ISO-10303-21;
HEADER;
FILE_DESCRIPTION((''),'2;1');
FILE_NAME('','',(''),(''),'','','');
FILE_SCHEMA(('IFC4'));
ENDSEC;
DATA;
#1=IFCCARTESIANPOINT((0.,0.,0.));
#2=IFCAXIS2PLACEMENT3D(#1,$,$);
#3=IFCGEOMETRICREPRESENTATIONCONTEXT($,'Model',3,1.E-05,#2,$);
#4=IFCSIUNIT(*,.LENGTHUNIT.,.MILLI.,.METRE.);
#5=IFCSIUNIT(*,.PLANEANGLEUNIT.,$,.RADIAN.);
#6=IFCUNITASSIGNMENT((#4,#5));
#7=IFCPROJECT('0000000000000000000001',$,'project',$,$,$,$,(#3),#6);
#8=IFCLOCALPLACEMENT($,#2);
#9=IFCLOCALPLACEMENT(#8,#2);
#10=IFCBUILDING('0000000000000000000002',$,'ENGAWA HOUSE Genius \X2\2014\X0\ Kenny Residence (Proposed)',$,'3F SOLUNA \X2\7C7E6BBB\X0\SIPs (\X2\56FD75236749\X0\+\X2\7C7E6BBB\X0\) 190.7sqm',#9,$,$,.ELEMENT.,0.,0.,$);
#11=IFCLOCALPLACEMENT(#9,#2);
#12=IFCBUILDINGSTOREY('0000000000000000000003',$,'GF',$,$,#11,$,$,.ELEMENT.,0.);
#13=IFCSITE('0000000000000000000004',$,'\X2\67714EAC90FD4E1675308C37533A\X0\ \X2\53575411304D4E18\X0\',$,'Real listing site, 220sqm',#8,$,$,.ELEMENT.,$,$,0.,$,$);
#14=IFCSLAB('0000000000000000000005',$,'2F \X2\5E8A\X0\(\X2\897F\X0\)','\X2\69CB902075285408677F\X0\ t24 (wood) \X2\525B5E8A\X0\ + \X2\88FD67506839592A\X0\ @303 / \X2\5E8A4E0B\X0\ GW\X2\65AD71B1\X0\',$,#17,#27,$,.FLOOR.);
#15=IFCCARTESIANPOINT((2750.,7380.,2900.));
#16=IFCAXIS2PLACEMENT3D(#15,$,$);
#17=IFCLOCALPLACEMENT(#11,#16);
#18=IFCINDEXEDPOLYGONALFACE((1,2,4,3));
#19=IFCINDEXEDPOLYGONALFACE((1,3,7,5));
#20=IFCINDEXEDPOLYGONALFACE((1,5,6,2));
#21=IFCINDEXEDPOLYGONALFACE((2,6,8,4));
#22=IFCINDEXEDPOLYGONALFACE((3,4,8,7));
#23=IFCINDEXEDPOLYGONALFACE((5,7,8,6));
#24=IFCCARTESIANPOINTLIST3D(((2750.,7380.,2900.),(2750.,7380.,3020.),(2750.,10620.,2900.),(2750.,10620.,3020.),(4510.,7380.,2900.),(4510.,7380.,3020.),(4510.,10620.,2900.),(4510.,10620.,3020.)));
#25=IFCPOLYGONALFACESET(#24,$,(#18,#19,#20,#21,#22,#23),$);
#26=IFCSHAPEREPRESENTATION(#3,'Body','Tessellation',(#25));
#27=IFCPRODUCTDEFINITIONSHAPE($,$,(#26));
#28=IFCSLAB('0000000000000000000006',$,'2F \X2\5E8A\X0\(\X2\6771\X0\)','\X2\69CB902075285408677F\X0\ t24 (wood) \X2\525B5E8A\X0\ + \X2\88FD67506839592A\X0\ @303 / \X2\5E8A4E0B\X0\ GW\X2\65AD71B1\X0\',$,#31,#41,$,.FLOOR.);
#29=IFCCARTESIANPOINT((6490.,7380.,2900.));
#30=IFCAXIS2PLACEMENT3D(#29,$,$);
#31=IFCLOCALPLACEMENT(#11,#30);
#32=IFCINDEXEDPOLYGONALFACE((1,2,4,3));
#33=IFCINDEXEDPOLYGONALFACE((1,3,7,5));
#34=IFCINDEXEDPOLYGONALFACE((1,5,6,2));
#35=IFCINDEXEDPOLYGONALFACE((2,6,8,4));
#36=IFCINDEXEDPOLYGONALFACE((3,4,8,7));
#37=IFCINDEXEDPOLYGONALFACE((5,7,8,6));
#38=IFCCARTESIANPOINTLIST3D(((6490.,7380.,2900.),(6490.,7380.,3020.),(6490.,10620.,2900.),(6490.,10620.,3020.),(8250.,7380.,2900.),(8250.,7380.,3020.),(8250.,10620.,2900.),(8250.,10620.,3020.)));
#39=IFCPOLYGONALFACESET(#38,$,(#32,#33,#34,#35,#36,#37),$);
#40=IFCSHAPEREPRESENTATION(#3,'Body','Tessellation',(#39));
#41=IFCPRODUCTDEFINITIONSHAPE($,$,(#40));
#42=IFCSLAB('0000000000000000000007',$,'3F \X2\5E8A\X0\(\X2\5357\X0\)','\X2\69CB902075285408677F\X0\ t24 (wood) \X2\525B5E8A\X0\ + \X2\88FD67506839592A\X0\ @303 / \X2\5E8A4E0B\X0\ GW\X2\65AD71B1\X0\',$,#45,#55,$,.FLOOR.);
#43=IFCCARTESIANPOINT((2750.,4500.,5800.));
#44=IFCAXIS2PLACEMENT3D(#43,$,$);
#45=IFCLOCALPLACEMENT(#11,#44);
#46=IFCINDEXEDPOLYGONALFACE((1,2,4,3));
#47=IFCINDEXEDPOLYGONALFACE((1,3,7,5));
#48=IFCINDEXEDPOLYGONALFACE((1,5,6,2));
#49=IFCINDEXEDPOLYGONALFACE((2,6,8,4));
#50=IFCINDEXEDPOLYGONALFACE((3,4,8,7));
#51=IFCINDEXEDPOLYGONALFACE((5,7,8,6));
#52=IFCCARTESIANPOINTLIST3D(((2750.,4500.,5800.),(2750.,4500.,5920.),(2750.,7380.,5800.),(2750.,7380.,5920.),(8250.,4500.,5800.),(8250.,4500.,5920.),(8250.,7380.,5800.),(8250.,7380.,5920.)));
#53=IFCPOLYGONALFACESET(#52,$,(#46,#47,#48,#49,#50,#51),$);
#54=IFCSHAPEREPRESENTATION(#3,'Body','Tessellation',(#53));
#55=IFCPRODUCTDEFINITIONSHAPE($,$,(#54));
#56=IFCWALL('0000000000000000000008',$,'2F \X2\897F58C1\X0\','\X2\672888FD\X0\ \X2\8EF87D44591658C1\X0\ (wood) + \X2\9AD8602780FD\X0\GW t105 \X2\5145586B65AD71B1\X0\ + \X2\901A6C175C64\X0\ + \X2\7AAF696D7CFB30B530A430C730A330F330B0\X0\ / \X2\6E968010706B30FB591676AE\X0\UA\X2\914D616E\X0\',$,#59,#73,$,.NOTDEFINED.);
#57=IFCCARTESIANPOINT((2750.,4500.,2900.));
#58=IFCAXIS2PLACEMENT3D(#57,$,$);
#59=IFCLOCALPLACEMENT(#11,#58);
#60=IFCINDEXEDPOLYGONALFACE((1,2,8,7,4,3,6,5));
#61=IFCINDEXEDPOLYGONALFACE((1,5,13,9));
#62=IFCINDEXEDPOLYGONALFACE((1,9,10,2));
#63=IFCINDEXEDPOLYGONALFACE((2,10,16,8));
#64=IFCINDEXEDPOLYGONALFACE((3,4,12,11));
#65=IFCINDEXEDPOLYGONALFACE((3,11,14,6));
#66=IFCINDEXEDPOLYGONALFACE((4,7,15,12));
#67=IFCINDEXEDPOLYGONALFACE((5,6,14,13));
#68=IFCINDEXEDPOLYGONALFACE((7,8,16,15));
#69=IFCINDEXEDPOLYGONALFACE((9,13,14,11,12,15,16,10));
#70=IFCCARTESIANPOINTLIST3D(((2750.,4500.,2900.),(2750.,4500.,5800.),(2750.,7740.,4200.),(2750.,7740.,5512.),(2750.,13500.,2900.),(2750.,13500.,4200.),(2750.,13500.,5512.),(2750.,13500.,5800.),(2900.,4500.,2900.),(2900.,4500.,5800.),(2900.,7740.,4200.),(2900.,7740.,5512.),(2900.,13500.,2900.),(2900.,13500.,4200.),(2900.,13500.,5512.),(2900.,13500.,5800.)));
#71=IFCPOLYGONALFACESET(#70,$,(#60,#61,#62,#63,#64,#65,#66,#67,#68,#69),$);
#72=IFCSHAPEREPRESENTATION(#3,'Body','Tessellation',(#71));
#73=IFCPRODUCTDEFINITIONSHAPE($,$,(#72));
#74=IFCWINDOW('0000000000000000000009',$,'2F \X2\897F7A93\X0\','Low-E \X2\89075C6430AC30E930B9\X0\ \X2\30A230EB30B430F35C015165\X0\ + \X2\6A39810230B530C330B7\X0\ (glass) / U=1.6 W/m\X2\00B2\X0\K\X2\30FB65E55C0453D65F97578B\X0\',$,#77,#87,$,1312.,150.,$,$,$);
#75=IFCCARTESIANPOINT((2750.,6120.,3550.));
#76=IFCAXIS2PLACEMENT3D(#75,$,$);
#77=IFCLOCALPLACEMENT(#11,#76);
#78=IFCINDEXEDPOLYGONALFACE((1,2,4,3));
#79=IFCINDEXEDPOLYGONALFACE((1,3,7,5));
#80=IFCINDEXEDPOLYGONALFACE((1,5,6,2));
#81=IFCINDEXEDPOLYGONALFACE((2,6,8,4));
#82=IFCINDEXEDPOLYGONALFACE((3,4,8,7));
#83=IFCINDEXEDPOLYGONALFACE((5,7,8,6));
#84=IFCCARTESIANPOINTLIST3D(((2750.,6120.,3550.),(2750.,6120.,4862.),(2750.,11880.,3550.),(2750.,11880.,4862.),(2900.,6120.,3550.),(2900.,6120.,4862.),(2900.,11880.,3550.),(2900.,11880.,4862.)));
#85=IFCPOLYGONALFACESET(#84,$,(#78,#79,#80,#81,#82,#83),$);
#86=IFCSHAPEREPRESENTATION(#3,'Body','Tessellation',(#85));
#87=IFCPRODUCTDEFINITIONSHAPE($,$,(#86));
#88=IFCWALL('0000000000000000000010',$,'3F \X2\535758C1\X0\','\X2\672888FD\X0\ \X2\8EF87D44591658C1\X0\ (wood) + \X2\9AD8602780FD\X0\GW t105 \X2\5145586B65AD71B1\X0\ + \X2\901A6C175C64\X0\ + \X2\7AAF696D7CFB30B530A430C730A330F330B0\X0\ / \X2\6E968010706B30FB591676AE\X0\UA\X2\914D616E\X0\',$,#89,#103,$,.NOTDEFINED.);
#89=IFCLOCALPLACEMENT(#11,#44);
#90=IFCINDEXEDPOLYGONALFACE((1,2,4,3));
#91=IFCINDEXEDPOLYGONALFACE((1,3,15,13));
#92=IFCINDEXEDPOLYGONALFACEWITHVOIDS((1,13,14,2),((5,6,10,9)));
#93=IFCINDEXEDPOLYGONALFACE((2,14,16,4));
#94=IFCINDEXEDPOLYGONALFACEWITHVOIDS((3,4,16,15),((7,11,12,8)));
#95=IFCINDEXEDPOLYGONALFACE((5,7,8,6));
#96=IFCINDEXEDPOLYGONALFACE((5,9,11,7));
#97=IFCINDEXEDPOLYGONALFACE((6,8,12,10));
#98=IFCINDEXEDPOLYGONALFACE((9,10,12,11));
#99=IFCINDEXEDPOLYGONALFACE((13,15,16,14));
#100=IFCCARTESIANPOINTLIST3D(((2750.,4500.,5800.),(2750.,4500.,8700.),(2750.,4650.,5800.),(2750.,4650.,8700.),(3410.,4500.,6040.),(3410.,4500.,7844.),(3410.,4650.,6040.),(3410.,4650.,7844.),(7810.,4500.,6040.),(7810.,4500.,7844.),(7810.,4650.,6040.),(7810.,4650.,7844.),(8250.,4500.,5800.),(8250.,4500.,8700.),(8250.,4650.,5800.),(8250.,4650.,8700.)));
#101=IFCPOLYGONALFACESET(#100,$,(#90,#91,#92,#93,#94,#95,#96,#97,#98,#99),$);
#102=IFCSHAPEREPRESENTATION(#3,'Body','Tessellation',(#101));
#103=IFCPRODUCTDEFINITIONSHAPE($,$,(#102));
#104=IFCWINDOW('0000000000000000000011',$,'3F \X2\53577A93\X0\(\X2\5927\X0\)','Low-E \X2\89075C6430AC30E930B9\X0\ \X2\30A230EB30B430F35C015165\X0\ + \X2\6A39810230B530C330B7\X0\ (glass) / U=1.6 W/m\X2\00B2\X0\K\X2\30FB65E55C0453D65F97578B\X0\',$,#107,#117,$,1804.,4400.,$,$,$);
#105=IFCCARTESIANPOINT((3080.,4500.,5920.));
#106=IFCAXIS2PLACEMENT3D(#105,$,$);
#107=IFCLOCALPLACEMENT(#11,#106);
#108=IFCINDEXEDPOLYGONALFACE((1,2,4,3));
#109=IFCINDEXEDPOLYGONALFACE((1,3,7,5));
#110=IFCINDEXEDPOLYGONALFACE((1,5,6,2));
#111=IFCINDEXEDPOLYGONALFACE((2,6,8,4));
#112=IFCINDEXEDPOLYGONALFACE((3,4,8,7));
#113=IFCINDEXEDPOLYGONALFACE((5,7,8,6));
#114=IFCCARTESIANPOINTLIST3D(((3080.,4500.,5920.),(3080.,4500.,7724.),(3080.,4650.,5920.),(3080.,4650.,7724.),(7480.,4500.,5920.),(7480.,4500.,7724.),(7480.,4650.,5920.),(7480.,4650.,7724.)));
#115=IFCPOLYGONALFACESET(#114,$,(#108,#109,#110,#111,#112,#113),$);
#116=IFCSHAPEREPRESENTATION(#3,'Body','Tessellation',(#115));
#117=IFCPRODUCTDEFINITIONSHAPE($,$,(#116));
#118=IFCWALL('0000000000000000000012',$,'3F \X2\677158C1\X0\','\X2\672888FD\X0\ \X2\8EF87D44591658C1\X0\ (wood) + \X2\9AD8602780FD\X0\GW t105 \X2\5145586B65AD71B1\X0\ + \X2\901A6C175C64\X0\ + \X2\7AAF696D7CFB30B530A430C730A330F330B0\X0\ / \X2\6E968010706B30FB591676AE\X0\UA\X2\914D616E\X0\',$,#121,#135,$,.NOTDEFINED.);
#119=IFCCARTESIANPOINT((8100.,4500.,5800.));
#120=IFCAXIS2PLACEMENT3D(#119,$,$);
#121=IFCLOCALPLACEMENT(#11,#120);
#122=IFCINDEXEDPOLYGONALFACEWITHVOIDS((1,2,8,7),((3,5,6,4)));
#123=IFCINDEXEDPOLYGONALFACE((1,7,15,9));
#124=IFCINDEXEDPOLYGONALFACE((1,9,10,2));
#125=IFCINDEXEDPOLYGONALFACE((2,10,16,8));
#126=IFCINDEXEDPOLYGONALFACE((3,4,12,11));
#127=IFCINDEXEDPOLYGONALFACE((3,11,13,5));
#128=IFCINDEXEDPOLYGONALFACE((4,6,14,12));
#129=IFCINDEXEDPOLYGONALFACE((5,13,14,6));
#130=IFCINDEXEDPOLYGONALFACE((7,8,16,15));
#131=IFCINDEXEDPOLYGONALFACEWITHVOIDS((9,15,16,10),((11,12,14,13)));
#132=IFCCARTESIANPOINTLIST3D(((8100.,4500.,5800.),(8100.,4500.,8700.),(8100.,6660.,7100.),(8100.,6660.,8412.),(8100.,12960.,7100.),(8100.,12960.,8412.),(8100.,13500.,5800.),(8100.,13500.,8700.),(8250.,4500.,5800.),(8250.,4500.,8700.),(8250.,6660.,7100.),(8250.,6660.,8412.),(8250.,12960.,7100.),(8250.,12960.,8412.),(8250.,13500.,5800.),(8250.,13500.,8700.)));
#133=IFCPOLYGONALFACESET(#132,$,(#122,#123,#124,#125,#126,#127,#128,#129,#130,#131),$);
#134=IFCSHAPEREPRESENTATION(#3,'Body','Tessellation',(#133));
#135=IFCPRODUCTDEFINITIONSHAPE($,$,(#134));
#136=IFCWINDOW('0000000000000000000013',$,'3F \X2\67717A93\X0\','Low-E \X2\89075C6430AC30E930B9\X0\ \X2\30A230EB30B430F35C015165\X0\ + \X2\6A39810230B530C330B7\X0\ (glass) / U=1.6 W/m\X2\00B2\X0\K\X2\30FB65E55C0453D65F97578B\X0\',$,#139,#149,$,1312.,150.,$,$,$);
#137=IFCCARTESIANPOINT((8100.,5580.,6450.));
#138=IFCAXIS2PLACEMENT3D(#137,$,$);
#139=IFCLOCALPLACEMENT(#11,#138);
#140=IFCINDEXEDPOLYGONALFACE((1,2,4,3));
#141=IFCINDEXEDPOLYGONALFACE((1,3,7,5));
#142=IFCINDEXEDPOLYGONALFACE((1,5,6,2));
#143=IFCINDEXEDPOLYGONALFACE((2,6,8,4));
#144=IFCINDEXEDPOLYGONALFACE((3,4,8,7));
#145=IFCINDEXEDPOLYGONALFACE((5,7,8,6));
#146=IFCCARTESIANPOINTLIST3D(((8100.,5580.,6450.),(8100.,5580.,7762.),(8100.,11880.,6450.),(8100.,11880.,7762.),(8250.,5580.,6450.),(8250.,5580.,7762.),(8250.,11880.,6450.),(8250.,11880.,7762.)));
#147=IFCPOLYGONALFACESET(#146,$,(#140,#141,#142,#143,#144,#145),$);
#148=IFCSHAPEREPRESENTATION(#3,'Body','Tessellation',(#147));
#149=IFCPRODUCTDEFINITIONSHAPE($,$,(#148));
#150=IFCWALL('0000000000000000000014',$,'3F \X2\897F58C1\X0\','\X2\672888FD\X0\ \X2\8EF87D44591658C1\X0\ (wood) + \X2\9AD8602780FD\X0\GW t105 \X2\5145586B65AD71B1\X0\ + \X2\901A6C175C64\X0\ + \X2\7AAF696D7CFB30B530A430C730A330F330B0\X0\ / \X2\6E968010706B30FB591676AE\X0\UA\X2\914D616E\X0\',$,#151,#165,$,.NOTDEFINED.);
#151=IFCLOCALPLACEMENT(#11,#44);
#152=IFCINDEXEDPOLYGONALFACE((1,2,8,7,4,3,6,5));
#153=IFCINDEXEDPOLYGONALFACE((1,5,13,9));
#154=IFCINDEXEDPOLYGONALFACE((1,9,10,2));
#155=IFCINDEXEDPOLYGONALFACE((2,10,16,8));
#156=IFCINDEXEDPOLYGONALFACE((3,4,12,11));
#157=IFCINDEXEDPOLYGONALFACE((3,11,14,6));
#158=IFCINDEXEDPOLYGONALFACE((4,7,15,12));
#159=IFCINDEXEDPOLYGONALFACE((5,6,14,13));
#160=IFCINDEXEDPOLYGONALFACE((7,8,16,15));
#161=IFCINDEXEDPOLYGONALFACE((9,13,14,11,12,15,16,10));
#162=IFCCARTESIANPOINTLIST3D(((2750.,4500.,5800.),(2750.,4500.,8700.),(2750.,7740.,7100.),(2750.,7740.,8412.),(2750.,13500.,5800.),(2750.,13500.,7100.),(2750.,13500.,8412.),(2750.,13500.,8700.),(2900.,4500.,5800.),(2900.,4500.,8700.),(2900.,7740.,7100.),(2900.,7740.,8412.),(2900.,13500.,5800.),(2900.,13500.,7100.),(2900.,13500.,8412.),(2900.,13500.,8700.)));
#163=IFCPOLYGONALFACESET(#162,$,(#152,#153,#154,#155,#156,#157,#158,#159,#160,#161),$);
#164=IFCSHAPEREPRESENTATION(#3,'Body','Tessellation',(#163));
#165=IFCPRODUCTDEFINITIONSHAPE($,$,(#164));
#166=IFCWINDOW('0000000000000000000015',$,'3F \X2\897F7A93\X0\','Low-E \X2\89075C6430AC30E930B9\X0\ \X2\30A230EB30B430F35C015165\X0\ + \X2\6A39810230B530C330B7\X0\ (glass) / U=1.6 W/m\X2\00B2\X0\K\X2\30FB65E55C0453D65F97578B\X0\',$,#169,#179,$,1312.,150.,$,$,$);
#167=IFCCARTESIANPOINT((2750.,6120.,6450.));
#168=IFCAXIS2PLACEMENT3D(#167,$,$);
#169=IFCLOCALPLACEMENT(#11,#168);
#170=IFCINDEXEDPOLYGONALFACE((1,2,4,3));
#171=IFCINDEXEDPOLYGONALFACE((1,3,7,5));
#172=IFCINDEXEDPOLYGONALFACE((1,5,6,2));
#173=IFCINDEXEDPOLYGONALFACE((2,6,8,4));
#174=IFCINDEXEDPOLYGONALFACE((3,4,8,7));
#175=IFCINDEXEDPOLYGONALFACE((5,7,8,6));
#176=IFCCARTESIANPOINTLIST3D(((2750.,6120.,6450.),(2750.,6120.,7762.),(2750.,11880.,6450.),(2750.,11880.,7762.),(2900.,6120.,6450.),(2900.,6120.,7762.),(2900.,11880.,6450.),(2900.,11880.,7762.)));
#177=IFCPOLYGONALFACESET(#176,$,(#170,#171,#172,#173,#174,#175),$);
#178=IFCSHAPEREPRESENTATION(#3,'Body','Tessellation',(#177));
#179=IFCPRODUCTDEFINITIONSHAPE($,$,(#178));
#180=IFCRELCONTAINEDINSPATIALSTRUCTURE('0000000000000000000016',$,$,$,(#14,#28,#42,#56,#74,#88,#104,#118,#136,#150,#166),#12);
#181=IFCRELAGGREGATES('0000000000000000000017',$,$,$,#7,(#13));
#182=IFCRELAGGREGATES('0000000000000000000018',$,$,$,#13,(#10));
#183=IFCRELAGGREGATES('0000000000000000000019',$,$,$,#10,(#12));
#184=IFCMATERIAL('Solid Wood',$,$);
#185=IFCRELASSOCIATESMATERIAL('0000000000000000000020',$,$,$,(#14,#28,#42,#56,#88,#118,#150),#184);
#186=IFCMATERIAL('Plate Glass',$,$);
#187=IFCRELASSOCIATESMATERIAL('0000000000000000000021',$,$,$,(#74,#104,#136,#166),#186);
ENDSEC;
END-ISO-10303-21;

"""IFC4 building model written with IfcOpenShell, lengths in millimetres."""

from ifc_helpers import new_model, si_unit, frame, frame_2d, origin, place, context, project, spatial, rectangle, extrude, material, element, fill, save


model = new_model("IFC4")

# Units and contexts
model_context = context("Model", 3, precision=1e-05, world=origin())
ifc_project = project(units=[si_unit("LENGTHUNIT", "METRE", prefix="MILLI"), si_unit("PLANEANGLEUNIT", "RADIAN")], contexts=[model_context])

# Site, building, storey
site_placement = place(None, origin())
site = spatial("IfcSite", under=ifc_project, at=site_placement, Name="東京都世田谷区 南向き丘", ObjectType="Real listing site, 220sqm", CompositionType="ELEMENT", RefElevation=0.0)
building_placement = place(site_placement, origin())
building = spatial("IfcBuilding", under=site, at=building_placement, Name="ENGAWA HOUSE Genius — Kenny Residence (Proposed)", ObjectType="3F SOLUNA 籾殻SIPs (国産杉+籾殻) 190.7sqm", CompositionType="ELEMENT", ElevationOfRefHeight=0.0, ElevationOfTerrain=0.0)
storey_placement = place(building_placement, origin())
storey = spatial("IfcBuildingStorey", under=building, at=storey_placement, Name="GF", CompositionType="ELEMENT", Elevation=0.0)

# Slabs
ifc_material_1 = material(Name="Solid Wood")
slab_1_placement = place(storey_placement, frame((2750.0, 7380.0, 2900.0)))
element("IfcSlab", 1, at=slab_1_placement, inside=storey, material=ifc_material_1, Name="2F 床(西)", Description="構造用合板 t24 (wood) 剛床 + 製材根太 @303 / 床下 GW断熱", PredefinedType="FLOOR", context=model_context, shape_type="SweptSolid", body=[
    extrude(rectangle(XDim=1760.0, YDim=3240.0, at=frame_2d((880.0, 1620.0))), frame((2750.0, 7380.0, 2900.0)), (0.0, 0.0, 1.0), 120.0),
])
slab_2_placement = place(storey_placement, frame((6490.0, 7380.0, 2900.0)))
element("IfcSlab", 2, at=slab_2_placement, inside=storey, material=ifc_material_1, Name="2F 床(東)", Description="構造用合板 t24 (wood) 剛床 + 製材根太 @303 / 床下 GW断熱", PredefinedType="FLOOR", context=model_context, shape_type="SweptSolid", body=[
    extrude(rectangle(XDim=1760.0, YDim=3240.0, at=frame_2d((880.0, 1620.0))), frame((6490.0, 7380.0, 2900.0)), (0.0, 0.0, 1.0), 120.0),
])
slab_3_placement = place(storey_placement, frame((2750.0, 4500.0, 5800.0)))
element("IfcSlab", 3, at=slab_3_placement, inside=storey, material=ifc_material_1, Name="3F 床(南)", Description="構造用合板 t24 (wood) 剛床 + 製材根太 @303 / 床下 GW断熱", PredefinedType="FLOOR", context=model_context, shape_type="SweptSolid", body=[
    extrude(rectangle(XDim=5500.0, YDim=2880.0, at=frame_2d((2750.0, 1440.0))), frame((2750.0, 4500.0, 5800.0)), (0.0, 0.0, 1.0), 120.0),
])

# Walls, openings, windows
wall_1_placement = place(storey_placement, frame((2750.0, 4500.0, 2900.0)))
wall_1 = element("IfcWall", 4, at=wall_1_placement, inside=storey, material=ifc_material_1, Name="2F 西壁", Description="木製 軸組外壁 (wood) + 高性能GW t105 充填断熱 + 通気層 + 窯業系サイディング / 準耐火・外皮UA配慮", PredefinedType="NOTDEFINED", context=model_context, shape_type="SweptSolid", body=[
    extrude(rectangle(XDim=150.0, YDim=9000.0, at=frame_2d((75.0, 4500.0))), frame((2750.0, 4500.0, 2900.0)), (0.0, 0.0, 1.0), 2900.0),
])
opening_1_placement = place(storey_placement, frame((2750.0, 6120.0, 3550.0)))
opening_1 = element("IfcOpeningElement", 5, at=opening_1_placement, cuts=wall_1, PredefinedType="NOTDEFINED", context=model_context, shape_type="SweptSolid", body=[
    extrude(rectangle(XDim=150.0, YDim=5760.0, at=frame_2d((75.0, 2880.0))), frame((2750.0, 6120.0, 3550.0)), (0.0, 0.0, 1.0), 1312.0),
])
ifc_material_2 = material(Name="Plate Glass")
window_1_placement = place(storey_placement, frame((2750.0, 6120.0, 3550.0)))
window_1 = element("IfcWindow", 6, at=window_1_placement, inside=storey, material=ifc_material_2, Name="2F 西窓", Description="Low-E 複層ガラス アルゴン封入 + 樹脂サッシ (glass) / U=1.6 W/m²K・日射取得型", OverallHeight=1312.0, OverallWidth=150.0, context=model_context, shape_type="SweptSolid", body=[
    extrude(rectangle(XDim=150.0, YDim=5760.0, at=frame_2d((75.0, 2880.0))), frame((2750.0, 6120.0, 3550.0)), (0.0, 0.0, 1.0), 1312.0),
])
fill(opening_1, window_1)
wall_2_placement = place(storey_placement, frame((2750.0, 4500.0, 5800.0)))
wall_2 = element("IfcWall", 7, at=wall_2_placement, inside=storey, material=ifc_material_1, Name="3F 南壁", Description="木製 軸組外壁 (wood) + 高性能GW t105 充填断熱 + 通気層 + 窯業系サイディング / 準耐火・外皮UA配慮", PredefinedType="NOTDEFINED", context=model_context, shape_type="SweptSolid", body=[
    extrude(rectangle(XDim=5500.0, YDim=150.0, at=frame_2d((2750.0, 75.0))), frame((2750.0, 4500.0, 5800.0)), (0.0, 0.0, 1.0), 2900.0),
])
opening_2_placement = place(storey_placement, frame((3080.0, 4500.0, 5920.0)))
opening_2 = element("IfcOpeningElement", 8, at=opening_2_placement, cuts=wall_2, PredefinedType="NOTDEFINED", context=model_context, shape_type="SweptSolid", body=[
    extrude(rectangle(XDim=4400.0, YDim=150.0, at=frame_2d((2200.0, 75.0))), frame((3080.0, 4500.0, 5920.0)), (0.0, 0.0, 1.0), 1804.0),
])
window_2_placement = place(storey_placement, frame((3080.0, 4500.0, 5920.0)))
window_2 = element("IfcWindow", 9, at=window_2_placement, inside=storey, material=ifc_material_2, Name="3F 南窓(大)", Description="Low-E 複層ガラス アルゴン封入 + 樹脂サッシ (glass) / U=1.6 W/m²K・日射取得型", OverallHeight=1804.0, OverallWidth=4400.0, context=model_context, shape_type="SweptSolid", body=[
    extrude(rectangle(XDim=4400.0, YDim=150.0, at=frame_2d((2200.0, 75.0))), frame((3080.0, 4500.0, 5920.0)), (0.0, 0.0, 1.0), 1804.0),
])
fill(opening_2, window_2)
wall_3_placement = place(storey_placement, frame((8100.0, 4500.0, 5800.0)))
wall_3 = element("IfcWall", 10, at=wall_3_placement, inside=storey, material=ifc_material_1, Name="3F 東壁", Description="木製 軸組外壁 (wood) + 高性能GW t105 充填断熱 + 通気層 + 窯業系サイディング / 準耐火・外皮UA配慮", PredefinedType="NOTDEFINED", context=model_context, shape_type="SweptSolid", body=[
    extrude(rectangle(XDim=150.0, YDim=9000.0, at=frame_2d((75.0, 4500.0))), frame((8100.0, 4500.0, 5800.0)), (0.0, 0.0, 1.0), 2900.0),
])
opening_3_placement = place(storey_placement, frame((8100.0, 5580.0, 6450.0)))
opening_3 = element("IfcOpeningElement", 11, at=opening_3_placement, cuts=wall_3, PredefinedType="NOTDEFINED", context=model_context, shape_type="SweptSolid", body=[
    extrude(rectangle(XDim=150.0, YDim=6300.0, at=frame_2d((75.0, 3150.0))), frame((8100.0, 5580.0, 6450.0)), (0.0, 0.0, 1.0), 1312.0),
])
window_3_placement = place(storey_placement, frame((8100.0, 5580.0, 6450.0)))
window_3 = element("IfcWindow", 12, at=window_3_placement, inside=storey, material=ifc_material_2, Name="3F 東窓", Description="Low-E 複層ガラス アルゴン封入 + 樹脂サッシ (glass) / U=1.6 W/m²K・日射取得型", OverallHeight=1312.0, OverallWidth=150.0, context=model_context, shape_type="SweptSolid", body=[
    extrude(rectangle(XDim=150.0, YDim=6300.0, at=frame_2d((75.0, 3150.0))), frame((8100.0, 5580.0, 6450.0)), (0.0, 0.0, 1.0), 1312.0),
])
fill(opening_3, window_3)
wall_4_placement = place(storey_placement, frame((2750.0, 4500.0, 5800.0)))
wall_4 = element("IfcWall", 13, at=wall_4_placement, inside=storey, material=ifc_material_1, Name="3F 西壁", Description="木製 軸組外壁 (wood) + 高性能GW t105 充填断熱 + 通気層 + 窯業系サイディング / 準耐火・外皮UA配慮", PredefinedType="NOTDEFINED", context=model_context, shape_type="SweptSolid", body=[
    extrude(rectangle(XDim=150.0, YDim=9000.0, at=frame_2d((75.0, 4500.0))), frame((2750.0, 4500.0, 5800.0)), (0.0, 0.0, 1.0), 2900.0),
])
opening_4_placement = place(storey_placement, frame((2750.0, 6120.0, 6450.0)))
opening_4 = element("IfcOpeningElement", 14, at=opening_4_placement, cuts=wall_4, PredefinedType="NOTDEFINED", context=model_context, shape_type="SweptSolid", body=[
    extrude(rectangle(XDim=150.0, YDim=5760.0, at=frame_2d((75.0, 2880.0))), frame((2750.0, 6120.0, 6450.0)), (0.0, 0.0, 1.0), 1312.0),
])
window_4_placement = place(storey_placement, frame((2750.0, 6120.0, 6450.0)))
window_4 = element("IfcWindow", 15, at=window_4_placement, inside=storey, material=ifc_material_2, Name="3F 西窓", Description="Low-E 複層ガラス アルゴン封入 + 樹脂サッシ (glass) / U=1.6 W/m²K・日射取得型", OverallHeight=1312.0, OverallWidth=150.0, context=model_context, shape_type="SweptSolid", body=[
    extrude(rectangle(XDim=150.0, YDim=5760.0, at=frame_2d((75.0, 2880.0))), frame((2750.0, 6120.0, 6450.0)), (0.0, 0.0, 1.0), 1312.0),
])
fill(opening_4, window_4)

save(model, "model.ifc")
